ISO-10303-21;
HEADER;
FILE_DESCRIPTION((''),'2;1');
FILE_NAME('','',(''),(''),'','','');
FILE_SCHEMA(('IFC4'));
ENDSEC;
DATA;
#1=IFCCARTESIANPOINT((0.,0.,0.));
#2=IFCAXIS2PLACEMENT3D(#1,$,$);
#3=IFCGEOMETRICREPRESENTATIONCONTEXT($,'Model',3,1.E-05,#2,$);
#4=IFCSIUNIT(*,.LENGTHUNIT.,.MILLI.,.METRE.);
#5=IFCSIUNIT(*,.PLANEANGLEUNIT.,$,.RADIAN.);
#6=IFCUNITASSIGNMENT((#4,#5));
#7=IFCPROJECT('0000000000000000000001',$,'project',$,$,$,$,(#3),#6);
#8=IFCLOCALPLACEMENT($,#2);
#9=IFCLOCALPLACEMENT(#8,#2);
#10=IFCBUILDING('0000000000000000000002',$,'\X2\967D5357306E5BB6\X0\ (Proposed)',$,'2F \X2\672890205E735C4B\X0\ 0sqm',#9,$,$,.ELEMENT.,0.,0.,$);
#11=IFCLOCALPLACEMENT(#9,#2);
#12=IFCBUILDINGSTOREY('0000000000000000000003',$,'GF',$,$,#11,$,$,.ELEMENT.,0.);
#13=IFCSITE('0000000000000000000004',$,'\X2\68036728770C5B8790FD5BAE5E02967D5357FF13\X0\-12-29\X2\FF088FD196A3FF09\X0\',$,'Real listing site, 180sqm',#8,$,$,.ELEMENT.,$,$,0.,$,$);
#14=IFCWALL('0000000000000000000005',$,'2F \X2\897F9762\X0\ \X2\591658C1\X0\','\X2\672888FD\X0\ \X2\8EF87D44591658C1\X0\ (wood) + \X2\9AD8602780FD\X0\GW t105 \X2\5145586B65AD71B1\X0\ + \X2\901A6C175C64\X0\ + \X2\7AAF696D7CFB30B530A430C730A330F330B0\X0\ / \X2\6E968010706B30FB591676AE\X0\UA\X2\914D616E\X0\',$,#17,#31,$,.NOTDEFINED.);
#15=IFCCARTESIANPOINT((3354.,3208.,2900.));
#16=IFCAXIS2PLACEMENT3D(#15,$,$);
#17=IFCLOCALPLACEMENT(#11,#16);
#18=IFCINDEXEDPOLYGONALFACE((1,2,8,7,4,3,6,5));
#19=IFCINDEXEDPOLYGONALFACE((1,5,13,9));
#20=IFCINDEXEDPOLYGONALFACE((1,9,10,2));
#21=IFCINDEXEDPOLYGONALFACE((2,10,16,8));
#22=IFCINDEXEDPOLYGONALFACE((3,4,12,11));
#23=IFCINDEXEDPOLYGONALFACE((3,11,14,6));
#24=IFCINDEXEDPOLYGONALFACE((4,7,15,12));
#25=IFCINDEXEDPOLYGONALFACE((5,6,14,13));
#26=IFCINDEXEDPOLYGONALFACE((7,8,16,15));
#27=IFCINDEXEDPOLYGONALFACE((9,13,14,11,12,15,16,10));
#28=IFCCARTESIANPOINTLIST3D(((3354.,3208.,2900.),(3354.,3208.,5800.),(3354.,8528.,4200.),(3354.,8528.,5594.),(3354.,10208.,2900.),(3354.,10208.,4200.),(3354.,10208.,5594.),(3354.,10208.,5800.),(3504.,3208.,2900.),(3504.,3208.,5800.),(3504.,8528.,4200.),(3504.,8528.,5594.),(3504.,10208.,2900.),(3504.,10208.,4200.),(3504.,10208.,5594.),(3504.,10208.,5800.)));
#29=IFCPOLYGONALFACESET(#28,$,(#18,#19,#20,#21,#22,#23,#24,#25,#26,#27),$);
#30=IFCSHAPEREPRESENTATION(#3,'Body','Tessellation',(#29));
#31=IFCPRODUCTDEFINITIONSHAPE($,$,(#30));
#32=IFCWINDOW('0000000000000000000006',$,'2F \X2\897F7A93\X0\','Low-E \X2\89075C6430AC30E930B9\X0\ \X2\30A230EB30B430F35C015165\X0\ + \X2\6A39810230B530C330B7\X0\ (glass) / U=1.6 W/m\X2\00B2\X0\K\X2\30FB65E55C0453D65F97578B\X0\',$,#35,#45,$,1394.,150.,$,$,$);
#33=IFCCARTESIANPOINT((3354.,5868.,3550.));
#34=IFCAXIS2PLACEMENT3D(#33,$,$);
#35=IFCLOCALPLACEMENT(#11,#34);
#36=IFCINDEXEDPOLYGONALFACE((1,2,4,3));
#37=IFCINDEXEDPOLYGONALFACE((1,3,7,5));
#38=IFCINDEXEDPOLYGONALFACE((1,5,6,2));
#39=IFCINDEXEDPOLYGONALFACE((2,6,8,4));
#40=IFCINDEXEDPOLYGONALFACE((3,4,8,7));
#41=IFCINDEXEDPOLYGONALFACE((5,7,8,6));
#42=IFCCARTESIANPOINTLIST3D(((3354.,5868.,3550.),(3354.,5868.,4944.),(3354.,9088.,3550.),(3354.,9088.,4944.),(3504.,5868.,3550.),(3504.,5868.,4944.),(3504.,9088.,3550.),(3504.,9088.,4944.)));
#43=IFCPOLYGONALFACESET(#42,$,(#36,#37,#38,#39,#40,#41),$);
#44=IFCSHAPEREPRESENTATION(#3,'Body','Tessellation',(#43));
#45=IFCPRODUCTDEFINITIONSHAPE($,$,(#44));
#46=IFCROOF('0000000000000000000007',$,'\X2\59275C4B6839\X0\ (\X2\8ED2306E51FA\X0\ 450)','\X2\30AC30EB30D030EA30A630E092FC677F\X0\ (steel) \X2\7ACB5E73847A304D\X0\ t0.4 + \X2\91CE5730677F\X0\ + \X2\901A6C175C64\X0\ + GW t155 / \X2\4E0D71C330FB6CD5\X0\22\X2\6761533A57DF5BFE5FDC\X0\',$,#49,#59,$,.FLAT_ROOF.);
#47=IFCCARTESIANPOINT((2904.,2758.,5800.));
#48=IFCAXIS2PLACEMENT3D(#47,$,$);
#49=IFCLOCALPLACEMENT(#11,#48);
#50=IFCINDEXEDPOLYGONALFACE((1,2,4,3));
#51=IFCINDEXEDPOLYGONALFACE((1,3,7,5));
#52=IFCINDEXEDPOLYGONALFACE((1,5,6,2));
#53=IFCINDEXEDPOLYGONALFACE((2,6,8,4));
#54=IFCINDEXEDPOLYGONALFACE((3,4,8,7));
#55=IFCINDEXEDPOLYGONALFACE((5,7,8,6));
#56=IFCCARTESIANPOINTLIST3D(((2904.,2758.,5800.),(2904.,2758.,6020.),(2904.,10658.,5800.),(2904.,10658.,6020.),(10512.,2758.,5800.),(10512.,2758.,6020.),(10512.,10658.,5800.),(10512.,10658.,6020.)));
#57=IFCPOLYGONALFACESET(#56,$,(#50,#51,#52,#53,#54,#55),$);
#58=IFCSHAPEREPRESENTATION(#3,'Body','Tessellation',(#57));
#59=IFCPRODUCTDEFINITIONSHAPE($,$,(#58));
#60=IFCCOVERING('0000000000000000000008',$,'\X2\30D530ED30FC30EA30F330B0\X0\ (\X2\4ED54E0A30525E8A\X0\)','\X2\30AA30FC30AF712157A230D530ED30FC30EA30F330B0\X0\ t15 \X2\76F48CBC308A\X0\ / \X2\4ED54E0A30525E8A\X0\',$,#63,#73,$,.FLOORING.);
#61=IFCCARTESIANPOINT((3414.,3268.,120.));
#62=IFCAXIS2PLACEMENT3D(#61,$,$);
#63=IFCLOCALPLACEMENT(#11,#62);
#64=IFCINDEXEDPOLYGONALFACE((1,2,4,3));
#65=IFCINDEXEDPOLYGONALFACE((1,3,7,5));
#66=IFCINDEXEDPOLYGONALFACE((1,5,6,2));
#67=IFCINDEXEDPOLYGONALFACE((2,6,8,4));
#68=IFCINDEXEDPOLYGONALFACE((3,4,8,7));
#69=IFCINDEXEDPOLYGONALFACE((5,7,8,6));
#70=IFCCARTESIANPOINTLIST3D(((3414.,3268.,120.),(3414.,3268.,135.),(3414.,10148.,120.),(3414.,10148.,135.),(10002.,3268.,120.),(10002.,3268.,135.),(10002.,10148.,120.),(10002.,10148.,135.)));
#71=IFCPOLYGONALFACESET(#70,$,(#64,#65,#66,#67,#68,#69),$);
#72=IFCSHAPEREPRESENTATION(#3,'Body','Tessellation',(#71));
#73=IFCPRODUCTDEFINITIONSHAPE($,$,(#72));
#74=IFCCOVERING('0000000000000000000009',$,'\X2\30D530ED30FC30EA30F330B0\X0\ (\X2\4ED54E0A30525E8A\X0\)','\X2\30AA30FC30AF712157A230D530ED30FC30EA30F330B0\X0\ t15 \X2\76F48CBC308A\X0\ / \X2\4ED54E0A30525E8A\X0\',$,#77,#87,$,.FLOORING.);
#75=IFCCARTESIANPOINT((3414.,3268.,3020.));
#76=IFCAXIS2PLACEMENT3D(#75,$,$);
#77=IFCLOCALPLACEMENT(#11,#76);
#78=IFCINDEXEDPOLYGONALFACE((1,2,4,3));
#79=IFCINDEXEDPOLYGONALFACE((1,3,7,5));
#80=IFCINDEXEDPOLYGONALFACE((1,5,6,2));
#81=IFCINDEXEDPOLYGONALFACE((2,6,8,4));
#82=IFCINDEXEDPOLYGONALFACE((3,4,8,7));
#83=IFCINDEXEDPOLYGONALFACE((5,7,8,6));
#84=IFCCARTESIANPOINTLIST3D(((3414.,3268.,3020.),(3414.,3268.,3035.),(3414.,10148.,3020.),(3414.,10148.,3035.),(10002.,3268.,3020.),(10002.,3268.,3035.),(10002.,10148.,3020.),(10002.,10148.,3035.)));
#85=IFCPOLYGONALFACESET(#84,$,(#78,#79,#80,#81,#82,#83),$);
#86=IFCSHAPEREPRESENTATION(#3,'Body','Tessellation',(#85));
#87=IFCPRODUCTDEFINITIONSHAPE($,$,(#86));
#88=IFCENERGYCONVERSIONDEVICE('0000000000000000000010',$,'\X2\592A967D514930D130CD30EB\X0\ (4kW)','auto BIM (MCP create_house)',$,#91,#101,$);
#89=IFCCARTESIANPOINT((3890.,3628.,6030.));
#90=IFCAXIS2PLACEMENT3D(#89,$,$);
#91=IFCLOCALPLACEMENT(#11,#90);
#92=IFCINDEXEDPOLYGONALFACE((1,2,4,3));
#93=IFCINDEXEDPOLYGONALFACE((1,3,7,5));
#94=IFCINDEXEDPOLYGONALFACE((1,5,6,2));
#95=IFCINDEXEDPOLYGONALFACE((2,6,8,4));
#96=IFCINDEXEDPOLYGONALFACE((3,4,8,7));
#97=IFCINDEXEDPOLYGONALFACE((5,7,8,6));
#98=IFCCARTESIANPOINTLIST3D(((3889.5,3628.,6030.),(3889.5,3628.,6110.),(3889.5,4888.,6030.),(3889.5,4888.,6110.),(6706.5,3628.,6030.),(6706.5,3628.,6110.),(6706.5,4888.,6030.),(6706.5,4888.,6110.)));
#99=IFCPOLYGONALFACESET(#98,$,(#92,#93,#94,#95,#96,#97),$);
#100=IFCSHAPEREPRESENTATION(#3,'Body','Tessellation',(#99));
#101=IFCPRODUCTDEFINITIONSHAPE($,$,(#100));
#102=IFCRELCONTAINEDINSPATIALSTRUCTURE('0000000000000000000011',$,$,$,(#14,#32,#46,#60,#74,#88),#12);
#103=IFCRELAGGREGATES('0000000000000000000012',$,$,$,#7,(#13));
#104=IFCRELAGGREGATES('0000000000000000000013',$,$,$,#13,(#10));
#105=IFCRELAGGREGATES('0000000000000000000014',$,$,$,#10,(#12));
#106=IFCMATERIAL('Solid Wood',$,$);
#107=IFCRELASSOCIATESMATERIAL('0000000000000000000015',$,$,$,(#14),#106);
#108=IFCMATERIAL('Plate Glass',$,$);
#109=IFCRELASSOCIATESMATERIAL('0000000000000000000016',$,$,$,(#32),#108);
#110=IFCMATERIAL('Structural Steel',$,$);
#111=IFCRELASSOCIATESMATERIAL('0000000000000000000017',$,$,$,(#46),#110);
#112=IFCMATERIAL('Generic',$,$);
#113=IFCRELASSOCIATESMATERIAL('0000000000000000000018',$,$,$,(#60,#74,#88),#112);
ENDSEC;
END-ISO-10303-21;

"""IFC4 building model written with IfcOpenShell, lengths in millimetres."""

from ifc_helpers import new_model, si_unit, frame, frame_2d, origin, place, context, project, spatial, rectangle, extrude, material, element, fill, save


model = new_model("IFC4")

# Units and contexts
model_context = context("Model", 3, precision=1e-05, world=origin())
ifc_project = project(units=[si_unit("LENGTHUNIT", "METRE", prefix="MILLI"), si_unit("PLANEANGLEUNIT", "RADIAN")], contexts=[model_context])

# Site, building, storey
site_placement = place(None, origin())
site = spatial("IfcSite", under=ifc_project, at=site_placement, Name="栃木県宇都宮市陽南３-12-29（近隣）", ObjectType="Real listing site, 180sqm", CompositionType="ELEMENT", RefElevation=0.0)
building_placement = place(site_placement, origin())
building = spatial("IfcBuilding", under=site, at=building_placement, Name="陽南の家 (Proposed)", ObjectType="2F 木造平屋 0sqm", CompositionType="ELEMENT", ElevationOfRefHeight=0.0, ElevationOfTerrain=0.0)
storey_placement = place(building_placement, origin())
storey = spatial("IfcBuildingStorey", under=building, at=storey_placement, Name="GF", CompositionType="ELEMENT", Elevation=0.0)

# Shared definitions
ifc_material_1 = material(Name="Solid Wood")

# Shared definitions
ifc_material_2 = material(Name="Plate Glass")

# Wall, opening, window
wall_1_placement = place(storey_placement, frame((3354.0, 3208.0, 2900.0)))
wall_1 = element("IfcWall", 1, at=wall_1_placement, inside=storey, material=ifc_material_1, Name="2F 西面 外壁", Description="木製 軸組外壁 (wood) + 高性能GW t105 充填断熱 + 通気層 + 窯業系サイディング / 準耐火・外皮UA配慮", PredefinedType="NOTDEFINED", context=model_context, shape_type="SweptSolid", body=[
    extrude(rectangle(XDim=150.0, YDim=7000.0, at=frame_2d((75.0, 3500.0))), frame((3354.0, 3208.0, 2900.0)), (0.0, 0.0, 1.0), 2900.0),
])
opening_1_placement = place(storey_placement, frame((3354.0, 5868.0, 3550.0)))
opening_1 = element("IfcOpeningElement", 2, at=opening_1_placement, cuts=wall_1, PredefinedType="NOTDEFINED", context=model_context, shape_type="SweptSolid", body=[
    extrude(rectangle(XDim=150.0, YDim=3220.0, at=frame_2d((75.0, 1610.0))), frame((3354.0, 5868.0, 3550.0)), (0.0, 0.0, 1.0), 1394.0),
])
window_1_placement = place(storey_placement, frame((3354.0, 5868.0, 3550.0)))
window_1 = element("IfcWindow", 3, at=window_1_placement, inside=storey, material=ifc_material_2, Name="2F 西窓", Description="Low-E 複層ガラス アルゴン封入 + 樹脂サッシ (glass) / U=1.6 W/m²K・日射取得型", OverallHeight=1394.0, OverallWidth=150.0, context=model_context, shape_type="SweptSolid", body=[
    extrude(rectangle(XDim=150.0, YDim=3220.0, at=frame_2d((75.0, 1610.0))), frame((3354.0, 5868.0, 3550.0)), (0.0, 0.0, 1.0), 1394.0),
])
fill(opening_1, window_1)

# Roof
ifc_material_3 = material(Name="Structural Steel")
roof_placement = place(storey_placement, frame((2904.0, 2758.0, 5800.0)))
element("IfcRoof", 4, at=roof_placement, inside=storey, material=ifc_material_3, Name="大屋根 (軒の出 450)", Description="ガルバリウム鋼板 (steel) 立平葺き t0.4 + 野地板 + 通気層 + GW t155 / 不燃・法22条区域対応", PredefinedType="FLAT_ROOF", context=model_context, shape_type="SweptSolid", body=[
    extrude(rectangle(XDim=7608.0, YDim=7900.0, at=frame_2d((3804.0, 3950.0))), frame((2904.0, 2758.0, 5800.0)), (0.0, 0.0, 1.0), 220.0),
])

# Coverings
ifc_material_4 = material(Name="Generic")
covering_1_placement = place(storey_placement, frame((3414.0, 3268.0, 120.0)))
element("IfcCovering", 5, at=covering_1_placement, inside=storey, material=ifc_material_4, Name="フローリング (仕上げ床)", Description="オーク無垢フローリング t15 直貼り / 仕上げ床", PredefinedType="FLOORING", context=model_context, shape_type="SweptSolid", body=[
    extrude(rectangle(XDim=6588.0, YDim=6880.0, at=frame_2d((3294.0, 3440.0))), frame((3414.0, 3268.0, 120.0)), (0.0, 0.0, 1.0), 15.0),
])
covering_2_placement = place(storey_placement, frame((3414.0, 3268.0, 3020.0)))
element("IfcCovering", 6, at=covering_2_placement, inside=storey, material=ifc_material_4, Name="フローリング (仕上げ床)", Description="オーク無垢フローリング t15 直貼り / 仕上げ床", PredefinedType="FLOORING", context=model_context, shape_type="SweptSolid", body=[
    extrude(rectangle(XDim=6588.0, YDim=6880.0, at=frame_2d((3294.0, 3440.0))), frame((3414.0, 3268.0, 3020.0)), (0.0, 0.0, 1.0), 15.0),
])

# Energy conversion device
energy_conversion_device_placement = place(storey_placement, frame((3890.0, 3628.0, 6030.0)))
element("IfcEnergyConversionDevice", 7, at=energy_conversion_device_placement, inside=storey, material=ifc_material_4, Name="太陽光パネル (4kW)", Description="auto BIM (MCP create_house)", context=model_context, shape_type="SweptSolid", body=[
    extrude(rectangle(XDim=2817.0, YDim=1260.0, at=frame_2d((1408.0, 630.0))), frame((3890.0, 3628.0, 6030.0)), (0.0, 0.0, 1.0), 80.0),
])

save(model, "model.ifc")
